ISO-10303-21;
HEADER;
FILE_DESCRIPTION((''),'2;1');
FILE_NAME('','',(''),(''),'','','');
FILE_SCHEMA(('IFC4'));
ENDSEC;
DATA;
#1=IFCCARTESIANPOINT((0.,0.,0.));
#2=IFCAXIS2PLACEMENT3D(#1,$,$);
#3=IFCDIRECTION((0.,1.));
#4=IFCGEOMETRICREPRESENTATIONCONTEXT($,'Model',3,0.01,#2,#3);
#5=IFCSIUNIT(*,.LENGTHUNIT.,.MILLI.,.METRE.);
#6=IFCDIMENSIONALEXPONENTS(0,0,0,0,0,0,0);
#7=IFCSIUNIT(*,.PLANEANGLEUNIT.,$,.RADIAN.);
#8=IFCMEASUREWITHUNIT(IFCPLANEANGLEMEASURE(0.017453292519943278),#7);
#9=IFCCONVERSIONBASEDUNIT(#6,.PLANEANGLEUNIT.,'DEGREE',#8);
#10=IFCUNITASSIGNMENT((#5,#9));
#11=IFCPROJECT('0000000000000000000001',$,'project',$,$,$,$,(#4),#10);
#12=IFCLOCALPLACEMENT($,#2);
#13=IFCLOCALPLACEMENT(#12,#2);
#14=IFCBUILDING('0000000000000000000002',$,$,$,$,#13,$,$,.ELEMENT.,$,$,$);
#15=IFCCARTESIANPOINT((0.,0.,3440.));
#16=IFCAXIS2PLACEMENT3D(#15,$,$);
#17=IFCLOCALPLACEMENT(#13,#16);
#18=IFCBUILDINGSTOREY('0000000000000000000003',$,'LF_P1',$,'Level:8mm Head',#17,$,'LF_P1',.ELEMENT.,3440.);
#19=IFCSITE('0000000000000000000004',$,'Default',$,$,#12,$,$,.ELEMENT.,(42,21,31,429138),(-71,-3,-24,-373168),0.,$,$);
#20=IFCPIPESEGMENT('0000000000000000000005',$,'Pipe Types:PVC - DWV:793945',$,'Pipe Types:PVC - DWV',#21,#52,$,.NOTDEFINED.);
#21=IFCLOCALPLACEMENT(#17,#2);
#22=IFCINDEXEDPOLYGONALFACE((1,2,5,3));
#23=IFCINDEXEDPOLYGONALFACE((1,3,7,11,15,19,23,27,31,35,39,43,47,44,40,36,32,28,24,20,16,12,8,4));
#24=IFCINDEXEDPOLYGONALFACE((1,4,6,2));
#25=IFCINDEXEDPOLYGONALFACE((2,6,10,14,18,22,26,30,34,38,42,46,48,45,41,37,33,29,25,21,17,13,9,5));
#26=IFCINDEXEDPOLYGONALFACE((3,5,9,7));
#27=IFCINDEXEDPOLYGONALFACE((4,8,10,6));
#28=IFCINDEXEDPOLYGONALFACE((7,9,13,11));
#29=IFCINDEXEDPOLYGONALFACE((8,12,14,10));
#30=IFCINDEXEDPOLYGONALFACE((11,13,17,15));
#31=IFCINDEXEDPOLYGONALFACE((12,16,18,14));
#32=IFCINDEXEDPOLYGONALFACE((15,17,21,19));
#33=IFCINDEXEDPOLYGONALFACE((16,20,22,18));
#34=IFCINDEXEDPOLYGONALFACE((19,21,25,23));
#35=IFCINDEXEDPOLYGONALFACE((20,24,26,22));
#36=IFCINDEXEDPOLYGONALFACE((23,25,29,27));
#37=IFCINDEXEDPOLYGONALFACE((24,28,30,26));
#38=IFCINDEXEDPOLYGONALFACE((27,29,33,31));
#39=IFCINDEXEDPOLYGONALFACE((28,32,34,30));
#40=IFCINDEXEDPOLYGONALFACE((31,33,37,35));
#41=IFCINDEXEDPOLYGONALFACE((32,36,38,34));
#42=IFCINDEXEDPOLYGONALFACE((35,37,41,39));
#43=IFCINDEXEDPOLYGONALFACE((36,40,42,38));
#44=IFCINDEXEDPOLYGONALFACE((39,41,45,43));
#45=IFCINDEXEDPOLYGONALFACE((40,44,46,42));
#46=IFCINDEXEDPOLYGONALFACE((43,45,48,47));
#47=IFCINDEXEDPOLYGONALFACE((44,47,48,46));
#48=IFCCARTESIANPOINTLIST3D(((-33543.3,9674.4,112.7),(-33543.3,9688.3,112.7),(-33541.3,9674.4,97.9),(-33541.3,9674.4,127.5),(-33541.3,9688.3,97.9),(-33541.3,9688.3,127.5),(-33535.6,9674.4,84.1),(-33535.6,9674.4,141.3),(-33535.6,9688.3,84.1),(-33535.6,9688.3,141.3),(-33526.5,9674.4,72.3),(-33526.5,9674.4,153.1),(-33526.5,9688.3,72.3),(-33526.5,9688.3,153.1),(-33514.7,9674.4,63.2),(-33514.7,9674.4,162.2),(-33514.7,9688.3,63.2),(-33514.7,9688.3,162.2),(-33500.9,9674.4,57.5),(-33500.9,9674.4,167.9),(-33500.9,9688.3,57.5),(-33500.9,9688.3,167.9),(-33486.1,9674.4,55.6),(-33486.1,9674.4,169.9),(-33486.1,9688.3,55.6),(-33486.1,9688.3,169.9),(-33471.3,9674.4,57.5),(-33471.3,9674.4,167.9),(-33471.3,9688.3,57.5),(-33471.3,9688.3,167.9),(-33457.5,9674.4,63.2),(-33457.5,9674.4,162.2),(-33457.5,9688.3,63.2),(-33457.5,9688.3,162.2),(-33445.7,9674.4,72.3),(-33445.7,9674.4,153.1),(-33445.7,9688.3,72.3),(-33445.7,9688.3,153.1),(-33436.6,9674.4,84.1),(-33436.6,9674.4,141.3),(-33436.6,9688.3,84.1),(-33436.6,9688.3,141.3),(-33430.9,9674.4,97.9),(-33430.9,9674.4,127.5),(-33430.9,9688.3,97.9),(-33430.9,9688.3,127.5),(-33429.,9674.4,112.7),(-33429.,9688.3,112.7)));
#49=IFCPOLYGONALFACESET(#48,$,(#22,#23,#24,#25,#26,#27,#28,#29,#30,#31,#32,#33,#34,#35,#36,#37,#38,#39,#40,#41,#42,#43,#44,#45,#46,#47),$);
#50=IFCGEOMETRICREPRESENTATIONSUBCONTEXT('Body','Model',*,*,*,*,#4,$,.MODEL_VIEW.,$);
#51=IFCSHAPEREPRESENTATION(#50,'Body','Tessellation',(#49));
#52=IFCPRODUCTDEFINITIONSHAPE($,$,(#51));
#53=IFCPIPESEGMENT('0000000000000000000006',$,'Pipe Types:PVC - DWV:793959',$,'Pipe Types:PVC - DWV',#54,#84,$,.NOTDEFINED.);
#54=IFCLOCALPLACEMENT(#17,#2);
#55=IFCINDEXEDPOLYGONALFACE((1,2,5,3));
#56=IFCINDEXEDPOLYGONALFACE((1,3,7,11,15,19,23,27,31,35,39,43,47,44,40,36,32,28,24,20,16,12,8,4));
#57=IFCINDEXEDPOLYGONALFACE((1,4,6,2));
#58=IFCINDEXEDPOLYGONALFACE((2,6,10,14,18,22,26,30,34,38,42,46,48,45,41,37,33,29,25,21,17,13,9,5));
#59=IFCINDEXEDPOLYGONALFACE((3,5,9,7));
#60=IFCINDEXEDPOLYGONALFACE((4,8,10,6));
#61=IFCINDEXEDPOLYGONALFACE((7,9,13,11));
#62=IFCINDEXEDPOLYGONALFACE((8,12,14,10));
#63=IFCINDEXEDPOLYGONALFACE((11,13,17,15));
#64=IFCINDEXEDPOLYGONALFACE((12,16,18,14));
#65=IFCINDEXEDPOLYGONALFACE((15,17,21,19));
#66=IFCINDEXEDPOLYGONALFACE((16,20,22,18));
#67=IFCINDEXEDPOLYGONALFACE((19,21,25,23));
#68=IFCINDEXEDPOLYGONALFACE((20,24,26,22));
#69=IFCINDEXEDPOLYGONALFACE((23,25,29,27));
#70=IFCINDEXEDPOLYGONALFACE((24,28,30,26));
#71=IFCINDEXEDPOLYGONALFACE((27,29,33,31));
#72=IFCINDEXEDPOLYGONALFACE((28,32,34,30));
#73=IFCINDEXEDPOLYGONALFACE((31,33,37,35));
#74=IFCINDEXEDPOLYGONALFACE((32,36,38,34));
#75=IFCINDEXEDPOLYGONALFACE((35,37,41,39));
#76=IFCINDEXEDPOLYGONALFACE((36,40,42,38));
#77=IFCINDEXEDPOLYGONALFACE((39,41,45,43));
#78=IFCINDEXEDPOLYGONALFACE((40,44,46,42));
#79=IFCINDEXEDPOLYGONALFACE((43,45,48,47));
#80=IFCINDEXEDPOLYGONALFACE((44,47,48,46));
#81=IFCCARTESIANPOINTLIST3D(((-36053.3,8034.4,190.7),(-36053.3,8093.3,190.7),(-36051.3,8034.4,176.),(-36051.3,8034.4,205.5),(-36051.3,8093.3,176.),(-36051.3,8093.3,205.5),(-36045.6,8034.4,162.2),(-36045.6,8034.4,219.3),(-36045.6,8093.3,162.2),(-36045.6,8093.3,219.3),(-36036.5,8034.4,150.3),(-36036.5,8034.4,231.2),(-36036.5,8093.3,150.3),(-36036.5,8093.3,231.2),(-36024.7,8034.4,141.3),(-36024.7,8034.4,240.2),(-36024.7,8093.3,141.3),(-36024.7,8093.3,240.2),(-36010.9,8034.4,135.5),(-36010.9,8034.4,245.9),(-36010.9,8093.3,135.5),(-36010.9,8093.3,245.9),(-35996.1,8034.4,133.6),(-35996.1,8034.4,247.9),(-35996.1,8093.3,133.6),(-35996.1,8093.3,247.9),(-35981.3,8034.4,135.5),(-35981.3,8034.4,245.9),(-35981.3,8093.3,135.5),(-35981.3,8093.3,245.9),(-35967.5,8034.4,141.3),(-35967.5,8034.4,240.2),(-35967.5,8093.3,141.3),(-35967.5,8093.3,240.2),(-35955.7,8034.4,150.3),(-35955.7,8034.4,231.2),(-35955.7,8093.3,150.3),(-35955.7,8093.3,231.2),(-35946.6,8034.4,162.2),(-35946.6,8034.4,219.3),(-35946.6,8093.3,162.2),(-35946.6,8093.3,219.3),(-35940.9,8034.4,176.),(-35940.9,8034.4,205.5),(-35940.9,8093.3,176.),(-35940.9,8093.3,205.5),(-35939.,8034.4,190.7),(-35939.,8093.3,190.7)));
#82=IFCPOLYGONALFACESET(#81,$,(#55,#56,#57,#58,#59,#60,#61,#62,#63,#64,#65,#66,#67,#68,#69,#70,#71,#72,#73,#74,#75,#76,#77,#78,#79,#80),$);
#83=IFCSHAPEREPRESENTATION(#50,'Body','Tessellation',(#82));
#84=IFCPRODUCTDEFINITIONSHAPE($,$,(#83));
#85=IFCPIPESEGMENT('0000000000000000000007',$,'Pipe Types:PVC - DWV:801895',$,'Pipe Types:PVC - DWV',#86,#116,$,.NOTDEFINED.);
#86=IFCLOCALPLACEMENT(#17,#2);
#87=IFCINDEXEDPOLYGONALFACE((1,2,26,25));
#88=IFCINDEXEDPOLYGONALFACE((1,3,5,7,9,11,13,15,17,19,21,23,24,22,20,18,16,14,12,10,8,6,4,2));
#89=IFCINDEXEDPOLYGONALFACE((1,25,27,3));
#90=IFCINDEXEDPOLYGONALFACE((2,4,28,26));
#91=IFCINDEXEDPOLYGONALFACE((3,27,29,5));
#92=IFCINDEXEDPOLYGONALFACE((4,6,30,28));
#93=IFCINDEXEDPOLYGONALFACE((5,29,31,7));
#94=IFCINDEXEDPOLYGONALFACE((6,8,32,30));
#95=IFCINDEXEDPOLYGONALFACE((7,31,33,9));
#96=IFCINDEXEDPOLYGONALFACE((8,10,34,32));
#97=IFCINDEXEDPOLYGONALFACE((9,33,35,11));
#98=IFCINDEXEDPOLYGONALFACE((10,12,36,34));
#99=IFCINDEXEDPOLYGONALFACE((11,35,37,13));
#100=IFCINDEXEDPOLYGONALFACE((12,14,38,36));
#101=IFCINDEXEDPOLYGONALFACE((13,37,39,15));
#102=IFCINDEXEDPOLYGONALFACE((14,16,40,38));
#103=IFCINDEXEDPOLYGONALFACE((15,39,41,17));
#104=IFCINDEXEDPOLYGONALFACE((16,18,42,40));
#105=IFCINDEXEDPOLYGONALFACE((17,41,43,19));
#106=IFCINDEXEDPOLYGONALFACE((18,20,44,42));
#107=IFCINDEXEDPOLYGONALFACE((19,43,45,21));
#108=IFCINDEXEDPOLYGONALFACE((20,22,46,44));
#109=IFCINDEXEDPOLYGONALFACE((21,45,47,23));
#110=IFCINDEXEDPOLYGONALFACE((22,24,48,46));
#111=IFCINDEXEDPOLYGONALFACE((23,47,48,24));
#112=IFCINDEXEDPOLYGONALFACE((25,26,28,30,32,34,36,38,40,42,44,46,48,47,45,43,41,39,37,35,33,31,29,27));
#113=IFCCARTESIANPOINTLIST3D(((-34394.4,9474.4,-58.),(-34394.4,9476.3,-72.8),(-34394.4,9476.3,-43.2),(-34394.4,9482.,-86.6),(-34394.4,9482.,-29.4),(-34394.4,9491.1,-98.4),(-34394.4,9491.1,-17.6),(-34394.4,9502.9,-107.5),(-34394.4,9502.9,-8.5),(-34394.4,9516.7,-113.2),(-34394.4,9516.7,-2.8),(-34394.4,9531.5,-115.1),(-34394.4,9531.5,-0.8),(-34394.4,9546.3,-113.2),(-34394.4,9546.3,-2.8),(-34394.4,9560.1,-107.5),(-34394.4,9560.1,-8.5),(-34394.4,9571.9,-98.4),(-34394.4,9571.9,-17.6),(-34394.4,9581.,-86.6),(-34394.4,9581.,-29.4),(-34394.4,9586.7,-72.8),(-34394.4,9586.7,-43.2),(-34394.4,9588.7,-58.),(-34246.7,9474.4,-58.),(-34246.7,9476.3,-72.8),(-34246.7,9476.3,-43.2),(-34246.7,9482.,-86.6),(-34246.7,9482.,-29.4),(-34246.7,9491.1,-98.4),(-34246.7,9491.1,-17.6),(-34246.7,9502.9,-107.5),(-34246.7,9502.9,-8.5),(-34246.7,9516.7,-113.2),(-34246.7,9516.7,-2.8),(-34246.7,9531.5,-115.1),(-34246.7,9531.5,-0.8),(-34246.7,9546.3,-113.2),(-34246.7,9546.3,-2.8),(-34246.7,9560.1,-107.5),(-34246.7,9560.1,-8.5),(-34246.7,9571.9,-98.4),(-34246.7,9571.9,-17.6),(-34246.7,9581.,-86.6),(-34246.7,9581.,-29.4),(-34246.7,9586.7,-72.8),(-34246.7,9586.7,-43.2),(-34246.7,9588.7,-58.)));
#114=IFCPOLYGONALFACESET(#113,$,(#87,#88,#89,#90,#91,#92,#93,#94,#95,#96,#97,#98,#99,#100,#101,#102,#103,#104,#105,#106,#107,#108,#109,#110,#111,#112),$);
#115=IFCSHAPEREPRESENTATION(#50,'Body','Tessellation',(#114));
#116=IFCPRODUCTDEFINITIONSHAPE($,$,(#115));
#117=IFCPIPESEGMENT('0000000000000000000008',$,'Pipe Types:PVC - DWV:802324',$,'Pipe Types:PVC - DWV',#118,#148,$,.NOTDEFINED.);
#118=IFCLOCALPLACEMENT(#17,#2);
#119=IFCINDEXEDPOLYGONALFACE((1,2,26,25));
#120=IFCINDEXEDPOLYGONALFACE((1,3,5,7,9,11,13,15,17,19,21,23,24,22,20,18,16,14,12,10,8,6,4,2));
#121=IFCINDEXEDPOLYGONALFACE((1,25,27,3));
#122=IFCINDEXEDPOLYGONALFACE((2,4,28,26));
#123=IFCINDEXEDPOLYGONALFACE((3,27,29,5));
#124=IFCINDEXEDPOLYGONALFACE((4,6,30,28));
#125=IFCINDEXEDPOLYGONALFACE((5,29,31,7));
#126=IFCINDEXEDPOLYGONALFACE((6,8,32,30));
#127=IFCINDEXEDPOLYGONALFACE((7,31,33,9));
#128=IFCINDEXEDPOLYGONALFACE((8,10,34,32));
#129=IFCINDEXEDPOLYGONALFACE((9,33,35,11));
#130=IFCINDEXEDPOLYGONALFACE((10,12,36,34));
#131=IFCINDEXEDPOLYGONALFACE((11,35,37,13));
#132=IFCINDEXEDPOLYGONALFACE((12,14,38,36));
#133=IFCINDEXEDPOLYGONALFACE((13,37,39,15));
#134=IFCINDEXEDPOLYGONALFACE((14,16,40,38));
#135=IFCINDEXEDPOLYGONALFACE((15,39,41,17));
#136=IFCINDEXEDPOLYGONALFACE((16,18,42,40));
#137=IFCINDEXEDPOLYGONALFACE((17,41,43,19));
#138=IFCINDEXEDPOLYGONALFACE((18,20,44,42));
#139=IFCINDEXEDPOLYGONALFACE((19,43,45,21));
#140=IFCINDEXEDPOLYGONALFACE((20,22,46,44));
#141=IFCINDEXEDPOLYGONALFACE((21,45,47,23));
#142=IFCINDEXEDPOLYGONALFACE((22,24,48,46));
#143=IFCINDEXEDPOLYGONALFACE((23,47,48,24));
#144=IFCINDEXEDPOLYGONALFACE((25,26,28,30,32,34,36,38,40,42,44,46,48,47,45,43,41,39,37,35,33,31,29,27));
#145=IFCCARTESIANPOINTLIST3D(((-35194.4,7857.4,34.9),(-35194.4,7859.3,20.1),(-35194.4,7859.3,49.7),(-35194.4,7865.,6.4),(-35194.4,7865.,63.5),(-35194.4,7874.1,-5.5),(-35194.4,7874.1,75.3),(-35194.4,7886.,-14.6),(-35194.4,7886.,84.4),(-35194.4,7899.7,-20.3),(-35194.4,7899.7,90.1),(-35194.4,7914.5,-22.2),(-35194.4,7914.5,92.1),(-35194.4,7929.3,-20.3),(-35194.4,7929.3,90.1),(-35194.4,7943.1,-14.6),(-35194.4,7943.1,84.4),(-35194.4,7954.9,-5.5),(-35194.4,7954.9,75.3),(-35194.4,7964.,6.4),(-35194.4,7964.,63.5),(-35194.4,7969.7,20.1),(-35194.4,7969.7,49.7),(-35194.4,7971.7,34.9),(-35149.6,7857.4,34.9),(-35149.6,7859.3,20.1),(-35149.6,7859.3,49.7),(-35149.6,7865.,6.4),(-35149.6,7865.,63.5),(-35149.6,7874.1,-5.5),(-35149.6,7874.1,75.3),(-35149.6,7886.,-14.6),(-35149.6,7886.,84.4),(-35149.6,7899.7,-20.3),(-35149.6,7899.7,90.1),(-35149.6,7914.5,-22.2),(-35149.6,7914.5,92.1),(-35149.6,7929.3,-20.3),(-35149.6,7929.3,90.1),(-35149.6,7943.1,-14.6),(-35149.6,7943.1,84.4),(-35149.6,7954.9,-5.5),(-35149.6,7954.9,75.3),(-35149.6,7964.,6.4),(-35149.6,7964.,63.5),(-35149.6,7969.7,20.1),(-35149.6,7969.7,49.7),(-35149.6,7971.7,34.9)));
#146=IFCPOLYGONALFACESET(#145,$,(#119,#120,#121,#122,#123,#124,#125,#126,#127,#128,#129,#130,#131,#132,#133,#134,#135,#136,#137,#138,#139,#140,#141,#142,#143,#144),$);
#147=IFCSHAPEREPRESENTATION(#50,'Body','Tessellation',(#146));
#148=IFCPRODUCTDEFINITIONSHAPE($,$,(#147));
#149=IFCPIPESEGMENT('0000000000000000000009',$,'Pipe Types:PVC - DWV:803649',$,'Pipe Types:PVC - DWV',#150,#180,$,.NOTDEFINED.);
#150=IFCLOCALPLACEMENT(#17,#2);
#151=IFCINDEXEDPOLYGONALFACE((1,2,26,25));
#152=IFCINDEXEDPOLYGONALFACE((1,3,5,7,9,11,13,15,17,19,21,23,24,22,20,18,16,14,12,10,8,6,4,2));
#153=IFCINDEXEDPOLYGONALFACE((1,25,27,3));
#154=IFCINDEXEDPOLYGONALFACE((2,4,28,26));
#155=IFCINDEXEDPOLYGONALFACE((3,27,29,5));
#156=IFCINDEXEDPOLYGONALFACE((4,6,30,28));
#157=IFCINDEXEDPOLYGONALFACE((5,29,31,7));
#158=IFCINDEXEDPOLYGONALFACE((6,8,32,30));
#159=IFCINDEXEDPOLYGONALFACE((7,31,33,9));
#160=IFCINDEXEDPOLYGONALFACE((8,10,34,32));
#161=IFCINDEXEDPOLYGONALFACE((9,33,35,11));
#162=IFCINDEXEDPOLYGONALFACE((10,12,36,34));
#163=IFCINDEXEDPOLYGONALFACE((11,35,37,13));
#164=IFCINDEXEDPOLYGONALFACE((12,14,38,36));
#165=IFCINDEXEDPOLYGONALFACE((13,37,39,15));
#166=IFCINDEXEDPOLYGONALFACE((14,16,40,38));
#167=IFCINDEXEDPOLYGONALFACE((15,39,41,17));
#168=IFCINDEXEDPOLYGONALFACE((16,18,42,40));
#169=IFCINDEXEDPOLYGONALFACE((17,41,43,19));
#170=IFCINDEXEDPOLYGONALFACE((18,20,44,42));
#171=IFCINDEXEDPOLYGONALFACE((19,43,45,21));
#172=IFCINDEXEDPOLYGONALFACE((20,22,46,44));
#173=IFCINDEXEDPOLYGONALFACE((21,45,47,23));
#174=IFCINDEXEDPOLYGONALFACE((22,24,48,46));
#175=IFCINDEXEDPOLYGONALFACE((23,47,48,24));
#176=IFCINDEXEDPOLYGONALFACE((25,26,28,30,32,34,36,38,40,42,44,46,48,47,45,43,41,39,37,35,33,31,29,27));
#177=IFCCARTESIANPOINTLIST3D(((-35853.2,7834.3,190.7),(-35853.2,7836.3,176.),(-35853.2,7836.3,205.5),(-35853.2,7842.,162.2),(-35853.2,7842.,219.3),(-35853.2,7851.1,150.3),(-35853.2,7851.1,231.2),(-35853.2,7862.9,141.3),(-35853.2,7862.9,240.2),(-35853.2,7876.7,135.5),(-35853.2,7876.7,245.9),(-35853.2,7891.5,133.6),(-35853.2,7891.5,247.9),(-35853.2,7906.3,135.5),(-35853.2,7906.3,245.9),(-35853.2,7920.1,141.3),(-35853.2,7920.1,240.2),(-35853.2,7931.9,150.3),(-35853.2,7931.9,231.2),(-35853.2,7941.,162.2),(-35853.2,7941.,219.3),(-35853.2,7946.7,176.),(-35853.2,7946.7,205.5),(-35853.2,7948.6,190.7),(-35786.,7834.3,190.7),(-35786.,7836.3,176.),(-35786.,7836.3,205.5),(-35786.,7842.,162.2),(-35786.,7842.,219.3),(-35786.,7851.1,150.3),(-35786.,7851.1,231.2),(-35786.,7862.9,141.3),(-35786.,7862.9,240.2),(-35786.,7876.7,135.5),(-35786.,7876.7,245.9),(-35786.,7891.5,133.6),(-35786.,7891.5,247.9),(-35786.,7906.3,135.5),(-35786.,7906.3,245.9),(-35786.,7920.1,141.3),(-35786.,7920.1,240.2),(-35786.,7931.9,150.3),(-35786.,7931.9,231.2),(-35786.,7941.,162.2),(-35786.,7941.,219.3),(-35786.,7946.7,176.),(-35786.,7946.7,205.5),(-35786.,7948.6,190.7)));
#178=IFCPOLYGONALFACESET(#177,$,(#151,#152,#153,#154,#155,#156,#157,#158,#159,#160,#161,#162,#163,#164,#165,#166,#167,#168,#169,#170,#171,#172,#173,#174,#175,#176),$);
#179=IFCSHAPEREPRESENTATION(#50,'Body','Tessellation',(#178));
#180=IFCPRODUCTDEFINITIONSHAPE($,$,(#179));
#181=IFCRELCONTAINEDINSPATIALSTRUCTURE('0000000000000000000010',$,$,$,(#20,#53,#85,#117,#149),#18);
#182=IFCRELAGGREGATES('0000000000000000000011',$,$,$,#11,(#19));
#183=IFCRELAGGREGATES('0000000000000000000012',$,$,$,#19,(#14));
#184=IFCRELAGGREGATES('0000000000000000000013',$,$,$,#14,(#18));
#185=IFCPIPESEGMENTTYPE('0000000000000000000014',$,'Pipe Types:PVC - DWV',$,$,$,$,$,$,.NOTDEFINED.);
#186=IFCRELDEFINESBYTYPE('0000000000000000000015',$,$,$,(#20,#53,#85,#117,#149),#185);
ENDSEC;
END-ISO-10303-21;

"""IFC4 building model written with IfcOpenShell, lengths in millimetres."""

from ifc_helpers import new_model, entity, si_unit, converted_unit, direction, frame, origin, place, context, subcontext, project, spatial, arc, indexed_curve, outline, extrude, type_object, element, save


model = new_model("IFC4")

# Units and contexts
model_context = context("Model", 3, precision=0.01, world=origin(), true_north=direction((0.0, 1.0)))
body_context = subcontext(model_context, "Body", "Model", "MODEL_VIEW")
ifc_project = project(units=[si_unit("LENGTHUNIT", "METRE", prefix="MILLI"), converted_unit("PLANEANGLEUNIT", "DEGREE", entity("IfcPlaneAngleMeasure", 0.017453292519943278), si_unit("PLANEANGLEUNIT", "RADIAN"), dimensions=[0, 0, 0, 0, 0, 0, 0])], contexts=[model_context])

# Site, building, storey
site_placement = place(None, origin())
site = spatial("IfcSite", under=ifc_project, at=site_placement, Name="Default", CompositionType="ELEMENT", RefLatitude=(42, 21, 31, 429138), RefLongitude=(-71, -3, -24, -373168), RefElevation=0.0)
building_placement = place(site_placement, origin())
building = spatial("IfcBuilding", under=site, at=building_placement, CompositionType="ELEMENT")
storey_placement = place(building_placement, frame((0.0, 0.0, 3440.0)))
storey = spatial("IfcBuildingStorey", under=building, at=storey_placement, Name="LF_P1", ObjectType="Level:8mm Head", LongName="LF_P1", CompositionType="ELEMENT", Elevation=3440.0)

# Pipe segments
pipe_segment_type_1 = type_object("IfcPipeSegmentType", Name="Pipe Types:PVC - DWV", PredefinedType="NOTDEFINED")
pipe_segment_1_placement = place(storey_placement, origin())
element("IfcPipeSegment", 1, at=pipe_segment_1_placement, inside=storey, type_object=pipe_segment_type_1, Name="Pipe Types:PVC - DWV:793945", ObjectType="Pipe Types:PVC - DWV", PredefinedType="NOTDEFINED", context=body_context, shape_type="SweptSolid", body=[
    extrude(outline(indexed_curve([(57.2, 0.0), (40.4, 40.4), (0.0, 57.2), (-40.4, 40.4), (-57.2, 0.0), (-40.4, -40.4), (0.0, -57.2), (40.4, -40.4)], segments=[arc(1, 2, 3), arc(3, 4, 5), arc(5, 6, 7), arc(7, 8, 1)], self_intersect=False)), frame((-33486.1, 9674.4, 112.7), z_axis=(0.0, 1.0, 0.0), x_axis=(-1.0, 0.0, 0.0)), (0.0, 0.0, 1.0), 13.9),
])
pipe_segment_2_placement = place(storey_placement, origin())
element("IfcPipeSegment", 2, at=pipe_segment_2_placement, inside=storey, type_object=pipe_segment_type_1, Name="Pipe Types:PVC - DWV:793959", ObjectType="Pipe Types:PVC - DWV", PredefinedType="NOTDEFINED", context=body_context, shape_type="SweptSolid", body=[
    extrude(outline(indexed_curve([(57.2, 0.0), (40.4, 40.4), (0.0, 57.2), (-40.4, 40.4), (-57.2, 0.0), (-40.4, -40.4), (0.0, -57.2), (40.4, -40.4)], segments=[arc(1, 2, 3), arc(3, 4, 5), arc(5, 6, 7), arc(7, 8, 1)], self_intersect=False)), frame((-35996.1, 8034.4, 190.7), z_axis=(0.0, 1.0, 0.0), x_axis=(-1.0, 0.0, 0.0)), (0.0, 0.0, 1.0), 59.0),
])
pipe_segment_3_placement = place(storey_placement, origin())
element("IfcPipeSegment", 3, at=pipe_segment_3_placement, inside=storey, type_object=pipe_segment_type_1, Name="Pipe Types:PVC - DWV:801895", ObjectType="Pipe Types:PVC - DWV", PredefinedType="NOTDEFINED", context=body_context, shape_type="SweptSolid", body=[
    extrude(outline(indexed_curve([(57.2, 0.0), (40.4, 40.4), (0.0, 57.2), (-40.4, 40.4), (-57.2, 0.0), (-40.4, -40.4), (0.0, -57.2), (40.4, -40.4)], segments=[arc(1, 2, 3), arc(3, 4, 5), arc(5, 6, 7), arc(7, 8, 1)], self_intersect=False)), frame((-34394.4, 9531.5, -58.0), z_axis=(1.0, 0.0, 0.0), x_axis=(0.0, 1.0, 0.0)), (0.0, 0.0, 1.0), 147.7),
])
pipe_segment_4_placement = place(storey_placement, origin())
element("IfcPipeSegment", 4, at=pipe_segment_4_placement, inside=storey, type_object=pipe_segment_type_1, Name="Pipe Types:PVC - DWV:802324", ObjectType="Pipe Types:PVC - DWV", PredefinedType="NOTDEFINED", context=body_context, shape_type="SweptSolid", body=[
    extrude(outline(indexed_curve([(57.2, 0.0), (40.4, 40.4), (0.0, 57.2), (-40.4, 40.4), (-57.2, 0.0), (-40.4, -40.4), (0.0, -57.2), (40.4, -40.4)], segments=[arc(1, 2, 3), arc(3, 4, 5), arc(5, 6, 7), arc(7, 8, 1)], self_intersect=False)), frame((-35194.4, 7914.5, 34.9), z_axis=(1.0, 0.0, 0.0), x_axis=(0.0, -1.0, 0.0)), (0.0, 0.0, 1.0), 44.8),
])
pipe_segment_5_placement = place(storey_placement, origin())
element("IfcPipeSegment", 5, at=pipe_segment_5_placement, inside=storey, type_object=pipe_segment_type_1, Name="Pipe Types:PVC - DWV:803649", ObjectType="Pipe Types:PVC - DWV", PredefinedType="NOTDEFINED", context=body_context, shape_type="SweptSolid", body=[
    extrude(outline(indexed_curve([(57.2, 0.0), (40.4, 40.4), (0.0, 57.2), (-40.4, 40.4), (-57.2, 0.0), (-40.4, -40.4), (0.0, -57.2), (40.4, -40.4)], segments=[arc(1, 2, 3), arc(3, 4, 5), arc(5, 6, 7), arc(7, 8, 1)], self_intersect=False)), frame((-35853.2, 7891.5, 190.7), z_axis=(1.0, 0.0, 0.0), x_axis=(0.0, -1.0, 0.0)), (0.0, 0.0, 1.0), 67.3),
])

save(model, "model.ifc")
